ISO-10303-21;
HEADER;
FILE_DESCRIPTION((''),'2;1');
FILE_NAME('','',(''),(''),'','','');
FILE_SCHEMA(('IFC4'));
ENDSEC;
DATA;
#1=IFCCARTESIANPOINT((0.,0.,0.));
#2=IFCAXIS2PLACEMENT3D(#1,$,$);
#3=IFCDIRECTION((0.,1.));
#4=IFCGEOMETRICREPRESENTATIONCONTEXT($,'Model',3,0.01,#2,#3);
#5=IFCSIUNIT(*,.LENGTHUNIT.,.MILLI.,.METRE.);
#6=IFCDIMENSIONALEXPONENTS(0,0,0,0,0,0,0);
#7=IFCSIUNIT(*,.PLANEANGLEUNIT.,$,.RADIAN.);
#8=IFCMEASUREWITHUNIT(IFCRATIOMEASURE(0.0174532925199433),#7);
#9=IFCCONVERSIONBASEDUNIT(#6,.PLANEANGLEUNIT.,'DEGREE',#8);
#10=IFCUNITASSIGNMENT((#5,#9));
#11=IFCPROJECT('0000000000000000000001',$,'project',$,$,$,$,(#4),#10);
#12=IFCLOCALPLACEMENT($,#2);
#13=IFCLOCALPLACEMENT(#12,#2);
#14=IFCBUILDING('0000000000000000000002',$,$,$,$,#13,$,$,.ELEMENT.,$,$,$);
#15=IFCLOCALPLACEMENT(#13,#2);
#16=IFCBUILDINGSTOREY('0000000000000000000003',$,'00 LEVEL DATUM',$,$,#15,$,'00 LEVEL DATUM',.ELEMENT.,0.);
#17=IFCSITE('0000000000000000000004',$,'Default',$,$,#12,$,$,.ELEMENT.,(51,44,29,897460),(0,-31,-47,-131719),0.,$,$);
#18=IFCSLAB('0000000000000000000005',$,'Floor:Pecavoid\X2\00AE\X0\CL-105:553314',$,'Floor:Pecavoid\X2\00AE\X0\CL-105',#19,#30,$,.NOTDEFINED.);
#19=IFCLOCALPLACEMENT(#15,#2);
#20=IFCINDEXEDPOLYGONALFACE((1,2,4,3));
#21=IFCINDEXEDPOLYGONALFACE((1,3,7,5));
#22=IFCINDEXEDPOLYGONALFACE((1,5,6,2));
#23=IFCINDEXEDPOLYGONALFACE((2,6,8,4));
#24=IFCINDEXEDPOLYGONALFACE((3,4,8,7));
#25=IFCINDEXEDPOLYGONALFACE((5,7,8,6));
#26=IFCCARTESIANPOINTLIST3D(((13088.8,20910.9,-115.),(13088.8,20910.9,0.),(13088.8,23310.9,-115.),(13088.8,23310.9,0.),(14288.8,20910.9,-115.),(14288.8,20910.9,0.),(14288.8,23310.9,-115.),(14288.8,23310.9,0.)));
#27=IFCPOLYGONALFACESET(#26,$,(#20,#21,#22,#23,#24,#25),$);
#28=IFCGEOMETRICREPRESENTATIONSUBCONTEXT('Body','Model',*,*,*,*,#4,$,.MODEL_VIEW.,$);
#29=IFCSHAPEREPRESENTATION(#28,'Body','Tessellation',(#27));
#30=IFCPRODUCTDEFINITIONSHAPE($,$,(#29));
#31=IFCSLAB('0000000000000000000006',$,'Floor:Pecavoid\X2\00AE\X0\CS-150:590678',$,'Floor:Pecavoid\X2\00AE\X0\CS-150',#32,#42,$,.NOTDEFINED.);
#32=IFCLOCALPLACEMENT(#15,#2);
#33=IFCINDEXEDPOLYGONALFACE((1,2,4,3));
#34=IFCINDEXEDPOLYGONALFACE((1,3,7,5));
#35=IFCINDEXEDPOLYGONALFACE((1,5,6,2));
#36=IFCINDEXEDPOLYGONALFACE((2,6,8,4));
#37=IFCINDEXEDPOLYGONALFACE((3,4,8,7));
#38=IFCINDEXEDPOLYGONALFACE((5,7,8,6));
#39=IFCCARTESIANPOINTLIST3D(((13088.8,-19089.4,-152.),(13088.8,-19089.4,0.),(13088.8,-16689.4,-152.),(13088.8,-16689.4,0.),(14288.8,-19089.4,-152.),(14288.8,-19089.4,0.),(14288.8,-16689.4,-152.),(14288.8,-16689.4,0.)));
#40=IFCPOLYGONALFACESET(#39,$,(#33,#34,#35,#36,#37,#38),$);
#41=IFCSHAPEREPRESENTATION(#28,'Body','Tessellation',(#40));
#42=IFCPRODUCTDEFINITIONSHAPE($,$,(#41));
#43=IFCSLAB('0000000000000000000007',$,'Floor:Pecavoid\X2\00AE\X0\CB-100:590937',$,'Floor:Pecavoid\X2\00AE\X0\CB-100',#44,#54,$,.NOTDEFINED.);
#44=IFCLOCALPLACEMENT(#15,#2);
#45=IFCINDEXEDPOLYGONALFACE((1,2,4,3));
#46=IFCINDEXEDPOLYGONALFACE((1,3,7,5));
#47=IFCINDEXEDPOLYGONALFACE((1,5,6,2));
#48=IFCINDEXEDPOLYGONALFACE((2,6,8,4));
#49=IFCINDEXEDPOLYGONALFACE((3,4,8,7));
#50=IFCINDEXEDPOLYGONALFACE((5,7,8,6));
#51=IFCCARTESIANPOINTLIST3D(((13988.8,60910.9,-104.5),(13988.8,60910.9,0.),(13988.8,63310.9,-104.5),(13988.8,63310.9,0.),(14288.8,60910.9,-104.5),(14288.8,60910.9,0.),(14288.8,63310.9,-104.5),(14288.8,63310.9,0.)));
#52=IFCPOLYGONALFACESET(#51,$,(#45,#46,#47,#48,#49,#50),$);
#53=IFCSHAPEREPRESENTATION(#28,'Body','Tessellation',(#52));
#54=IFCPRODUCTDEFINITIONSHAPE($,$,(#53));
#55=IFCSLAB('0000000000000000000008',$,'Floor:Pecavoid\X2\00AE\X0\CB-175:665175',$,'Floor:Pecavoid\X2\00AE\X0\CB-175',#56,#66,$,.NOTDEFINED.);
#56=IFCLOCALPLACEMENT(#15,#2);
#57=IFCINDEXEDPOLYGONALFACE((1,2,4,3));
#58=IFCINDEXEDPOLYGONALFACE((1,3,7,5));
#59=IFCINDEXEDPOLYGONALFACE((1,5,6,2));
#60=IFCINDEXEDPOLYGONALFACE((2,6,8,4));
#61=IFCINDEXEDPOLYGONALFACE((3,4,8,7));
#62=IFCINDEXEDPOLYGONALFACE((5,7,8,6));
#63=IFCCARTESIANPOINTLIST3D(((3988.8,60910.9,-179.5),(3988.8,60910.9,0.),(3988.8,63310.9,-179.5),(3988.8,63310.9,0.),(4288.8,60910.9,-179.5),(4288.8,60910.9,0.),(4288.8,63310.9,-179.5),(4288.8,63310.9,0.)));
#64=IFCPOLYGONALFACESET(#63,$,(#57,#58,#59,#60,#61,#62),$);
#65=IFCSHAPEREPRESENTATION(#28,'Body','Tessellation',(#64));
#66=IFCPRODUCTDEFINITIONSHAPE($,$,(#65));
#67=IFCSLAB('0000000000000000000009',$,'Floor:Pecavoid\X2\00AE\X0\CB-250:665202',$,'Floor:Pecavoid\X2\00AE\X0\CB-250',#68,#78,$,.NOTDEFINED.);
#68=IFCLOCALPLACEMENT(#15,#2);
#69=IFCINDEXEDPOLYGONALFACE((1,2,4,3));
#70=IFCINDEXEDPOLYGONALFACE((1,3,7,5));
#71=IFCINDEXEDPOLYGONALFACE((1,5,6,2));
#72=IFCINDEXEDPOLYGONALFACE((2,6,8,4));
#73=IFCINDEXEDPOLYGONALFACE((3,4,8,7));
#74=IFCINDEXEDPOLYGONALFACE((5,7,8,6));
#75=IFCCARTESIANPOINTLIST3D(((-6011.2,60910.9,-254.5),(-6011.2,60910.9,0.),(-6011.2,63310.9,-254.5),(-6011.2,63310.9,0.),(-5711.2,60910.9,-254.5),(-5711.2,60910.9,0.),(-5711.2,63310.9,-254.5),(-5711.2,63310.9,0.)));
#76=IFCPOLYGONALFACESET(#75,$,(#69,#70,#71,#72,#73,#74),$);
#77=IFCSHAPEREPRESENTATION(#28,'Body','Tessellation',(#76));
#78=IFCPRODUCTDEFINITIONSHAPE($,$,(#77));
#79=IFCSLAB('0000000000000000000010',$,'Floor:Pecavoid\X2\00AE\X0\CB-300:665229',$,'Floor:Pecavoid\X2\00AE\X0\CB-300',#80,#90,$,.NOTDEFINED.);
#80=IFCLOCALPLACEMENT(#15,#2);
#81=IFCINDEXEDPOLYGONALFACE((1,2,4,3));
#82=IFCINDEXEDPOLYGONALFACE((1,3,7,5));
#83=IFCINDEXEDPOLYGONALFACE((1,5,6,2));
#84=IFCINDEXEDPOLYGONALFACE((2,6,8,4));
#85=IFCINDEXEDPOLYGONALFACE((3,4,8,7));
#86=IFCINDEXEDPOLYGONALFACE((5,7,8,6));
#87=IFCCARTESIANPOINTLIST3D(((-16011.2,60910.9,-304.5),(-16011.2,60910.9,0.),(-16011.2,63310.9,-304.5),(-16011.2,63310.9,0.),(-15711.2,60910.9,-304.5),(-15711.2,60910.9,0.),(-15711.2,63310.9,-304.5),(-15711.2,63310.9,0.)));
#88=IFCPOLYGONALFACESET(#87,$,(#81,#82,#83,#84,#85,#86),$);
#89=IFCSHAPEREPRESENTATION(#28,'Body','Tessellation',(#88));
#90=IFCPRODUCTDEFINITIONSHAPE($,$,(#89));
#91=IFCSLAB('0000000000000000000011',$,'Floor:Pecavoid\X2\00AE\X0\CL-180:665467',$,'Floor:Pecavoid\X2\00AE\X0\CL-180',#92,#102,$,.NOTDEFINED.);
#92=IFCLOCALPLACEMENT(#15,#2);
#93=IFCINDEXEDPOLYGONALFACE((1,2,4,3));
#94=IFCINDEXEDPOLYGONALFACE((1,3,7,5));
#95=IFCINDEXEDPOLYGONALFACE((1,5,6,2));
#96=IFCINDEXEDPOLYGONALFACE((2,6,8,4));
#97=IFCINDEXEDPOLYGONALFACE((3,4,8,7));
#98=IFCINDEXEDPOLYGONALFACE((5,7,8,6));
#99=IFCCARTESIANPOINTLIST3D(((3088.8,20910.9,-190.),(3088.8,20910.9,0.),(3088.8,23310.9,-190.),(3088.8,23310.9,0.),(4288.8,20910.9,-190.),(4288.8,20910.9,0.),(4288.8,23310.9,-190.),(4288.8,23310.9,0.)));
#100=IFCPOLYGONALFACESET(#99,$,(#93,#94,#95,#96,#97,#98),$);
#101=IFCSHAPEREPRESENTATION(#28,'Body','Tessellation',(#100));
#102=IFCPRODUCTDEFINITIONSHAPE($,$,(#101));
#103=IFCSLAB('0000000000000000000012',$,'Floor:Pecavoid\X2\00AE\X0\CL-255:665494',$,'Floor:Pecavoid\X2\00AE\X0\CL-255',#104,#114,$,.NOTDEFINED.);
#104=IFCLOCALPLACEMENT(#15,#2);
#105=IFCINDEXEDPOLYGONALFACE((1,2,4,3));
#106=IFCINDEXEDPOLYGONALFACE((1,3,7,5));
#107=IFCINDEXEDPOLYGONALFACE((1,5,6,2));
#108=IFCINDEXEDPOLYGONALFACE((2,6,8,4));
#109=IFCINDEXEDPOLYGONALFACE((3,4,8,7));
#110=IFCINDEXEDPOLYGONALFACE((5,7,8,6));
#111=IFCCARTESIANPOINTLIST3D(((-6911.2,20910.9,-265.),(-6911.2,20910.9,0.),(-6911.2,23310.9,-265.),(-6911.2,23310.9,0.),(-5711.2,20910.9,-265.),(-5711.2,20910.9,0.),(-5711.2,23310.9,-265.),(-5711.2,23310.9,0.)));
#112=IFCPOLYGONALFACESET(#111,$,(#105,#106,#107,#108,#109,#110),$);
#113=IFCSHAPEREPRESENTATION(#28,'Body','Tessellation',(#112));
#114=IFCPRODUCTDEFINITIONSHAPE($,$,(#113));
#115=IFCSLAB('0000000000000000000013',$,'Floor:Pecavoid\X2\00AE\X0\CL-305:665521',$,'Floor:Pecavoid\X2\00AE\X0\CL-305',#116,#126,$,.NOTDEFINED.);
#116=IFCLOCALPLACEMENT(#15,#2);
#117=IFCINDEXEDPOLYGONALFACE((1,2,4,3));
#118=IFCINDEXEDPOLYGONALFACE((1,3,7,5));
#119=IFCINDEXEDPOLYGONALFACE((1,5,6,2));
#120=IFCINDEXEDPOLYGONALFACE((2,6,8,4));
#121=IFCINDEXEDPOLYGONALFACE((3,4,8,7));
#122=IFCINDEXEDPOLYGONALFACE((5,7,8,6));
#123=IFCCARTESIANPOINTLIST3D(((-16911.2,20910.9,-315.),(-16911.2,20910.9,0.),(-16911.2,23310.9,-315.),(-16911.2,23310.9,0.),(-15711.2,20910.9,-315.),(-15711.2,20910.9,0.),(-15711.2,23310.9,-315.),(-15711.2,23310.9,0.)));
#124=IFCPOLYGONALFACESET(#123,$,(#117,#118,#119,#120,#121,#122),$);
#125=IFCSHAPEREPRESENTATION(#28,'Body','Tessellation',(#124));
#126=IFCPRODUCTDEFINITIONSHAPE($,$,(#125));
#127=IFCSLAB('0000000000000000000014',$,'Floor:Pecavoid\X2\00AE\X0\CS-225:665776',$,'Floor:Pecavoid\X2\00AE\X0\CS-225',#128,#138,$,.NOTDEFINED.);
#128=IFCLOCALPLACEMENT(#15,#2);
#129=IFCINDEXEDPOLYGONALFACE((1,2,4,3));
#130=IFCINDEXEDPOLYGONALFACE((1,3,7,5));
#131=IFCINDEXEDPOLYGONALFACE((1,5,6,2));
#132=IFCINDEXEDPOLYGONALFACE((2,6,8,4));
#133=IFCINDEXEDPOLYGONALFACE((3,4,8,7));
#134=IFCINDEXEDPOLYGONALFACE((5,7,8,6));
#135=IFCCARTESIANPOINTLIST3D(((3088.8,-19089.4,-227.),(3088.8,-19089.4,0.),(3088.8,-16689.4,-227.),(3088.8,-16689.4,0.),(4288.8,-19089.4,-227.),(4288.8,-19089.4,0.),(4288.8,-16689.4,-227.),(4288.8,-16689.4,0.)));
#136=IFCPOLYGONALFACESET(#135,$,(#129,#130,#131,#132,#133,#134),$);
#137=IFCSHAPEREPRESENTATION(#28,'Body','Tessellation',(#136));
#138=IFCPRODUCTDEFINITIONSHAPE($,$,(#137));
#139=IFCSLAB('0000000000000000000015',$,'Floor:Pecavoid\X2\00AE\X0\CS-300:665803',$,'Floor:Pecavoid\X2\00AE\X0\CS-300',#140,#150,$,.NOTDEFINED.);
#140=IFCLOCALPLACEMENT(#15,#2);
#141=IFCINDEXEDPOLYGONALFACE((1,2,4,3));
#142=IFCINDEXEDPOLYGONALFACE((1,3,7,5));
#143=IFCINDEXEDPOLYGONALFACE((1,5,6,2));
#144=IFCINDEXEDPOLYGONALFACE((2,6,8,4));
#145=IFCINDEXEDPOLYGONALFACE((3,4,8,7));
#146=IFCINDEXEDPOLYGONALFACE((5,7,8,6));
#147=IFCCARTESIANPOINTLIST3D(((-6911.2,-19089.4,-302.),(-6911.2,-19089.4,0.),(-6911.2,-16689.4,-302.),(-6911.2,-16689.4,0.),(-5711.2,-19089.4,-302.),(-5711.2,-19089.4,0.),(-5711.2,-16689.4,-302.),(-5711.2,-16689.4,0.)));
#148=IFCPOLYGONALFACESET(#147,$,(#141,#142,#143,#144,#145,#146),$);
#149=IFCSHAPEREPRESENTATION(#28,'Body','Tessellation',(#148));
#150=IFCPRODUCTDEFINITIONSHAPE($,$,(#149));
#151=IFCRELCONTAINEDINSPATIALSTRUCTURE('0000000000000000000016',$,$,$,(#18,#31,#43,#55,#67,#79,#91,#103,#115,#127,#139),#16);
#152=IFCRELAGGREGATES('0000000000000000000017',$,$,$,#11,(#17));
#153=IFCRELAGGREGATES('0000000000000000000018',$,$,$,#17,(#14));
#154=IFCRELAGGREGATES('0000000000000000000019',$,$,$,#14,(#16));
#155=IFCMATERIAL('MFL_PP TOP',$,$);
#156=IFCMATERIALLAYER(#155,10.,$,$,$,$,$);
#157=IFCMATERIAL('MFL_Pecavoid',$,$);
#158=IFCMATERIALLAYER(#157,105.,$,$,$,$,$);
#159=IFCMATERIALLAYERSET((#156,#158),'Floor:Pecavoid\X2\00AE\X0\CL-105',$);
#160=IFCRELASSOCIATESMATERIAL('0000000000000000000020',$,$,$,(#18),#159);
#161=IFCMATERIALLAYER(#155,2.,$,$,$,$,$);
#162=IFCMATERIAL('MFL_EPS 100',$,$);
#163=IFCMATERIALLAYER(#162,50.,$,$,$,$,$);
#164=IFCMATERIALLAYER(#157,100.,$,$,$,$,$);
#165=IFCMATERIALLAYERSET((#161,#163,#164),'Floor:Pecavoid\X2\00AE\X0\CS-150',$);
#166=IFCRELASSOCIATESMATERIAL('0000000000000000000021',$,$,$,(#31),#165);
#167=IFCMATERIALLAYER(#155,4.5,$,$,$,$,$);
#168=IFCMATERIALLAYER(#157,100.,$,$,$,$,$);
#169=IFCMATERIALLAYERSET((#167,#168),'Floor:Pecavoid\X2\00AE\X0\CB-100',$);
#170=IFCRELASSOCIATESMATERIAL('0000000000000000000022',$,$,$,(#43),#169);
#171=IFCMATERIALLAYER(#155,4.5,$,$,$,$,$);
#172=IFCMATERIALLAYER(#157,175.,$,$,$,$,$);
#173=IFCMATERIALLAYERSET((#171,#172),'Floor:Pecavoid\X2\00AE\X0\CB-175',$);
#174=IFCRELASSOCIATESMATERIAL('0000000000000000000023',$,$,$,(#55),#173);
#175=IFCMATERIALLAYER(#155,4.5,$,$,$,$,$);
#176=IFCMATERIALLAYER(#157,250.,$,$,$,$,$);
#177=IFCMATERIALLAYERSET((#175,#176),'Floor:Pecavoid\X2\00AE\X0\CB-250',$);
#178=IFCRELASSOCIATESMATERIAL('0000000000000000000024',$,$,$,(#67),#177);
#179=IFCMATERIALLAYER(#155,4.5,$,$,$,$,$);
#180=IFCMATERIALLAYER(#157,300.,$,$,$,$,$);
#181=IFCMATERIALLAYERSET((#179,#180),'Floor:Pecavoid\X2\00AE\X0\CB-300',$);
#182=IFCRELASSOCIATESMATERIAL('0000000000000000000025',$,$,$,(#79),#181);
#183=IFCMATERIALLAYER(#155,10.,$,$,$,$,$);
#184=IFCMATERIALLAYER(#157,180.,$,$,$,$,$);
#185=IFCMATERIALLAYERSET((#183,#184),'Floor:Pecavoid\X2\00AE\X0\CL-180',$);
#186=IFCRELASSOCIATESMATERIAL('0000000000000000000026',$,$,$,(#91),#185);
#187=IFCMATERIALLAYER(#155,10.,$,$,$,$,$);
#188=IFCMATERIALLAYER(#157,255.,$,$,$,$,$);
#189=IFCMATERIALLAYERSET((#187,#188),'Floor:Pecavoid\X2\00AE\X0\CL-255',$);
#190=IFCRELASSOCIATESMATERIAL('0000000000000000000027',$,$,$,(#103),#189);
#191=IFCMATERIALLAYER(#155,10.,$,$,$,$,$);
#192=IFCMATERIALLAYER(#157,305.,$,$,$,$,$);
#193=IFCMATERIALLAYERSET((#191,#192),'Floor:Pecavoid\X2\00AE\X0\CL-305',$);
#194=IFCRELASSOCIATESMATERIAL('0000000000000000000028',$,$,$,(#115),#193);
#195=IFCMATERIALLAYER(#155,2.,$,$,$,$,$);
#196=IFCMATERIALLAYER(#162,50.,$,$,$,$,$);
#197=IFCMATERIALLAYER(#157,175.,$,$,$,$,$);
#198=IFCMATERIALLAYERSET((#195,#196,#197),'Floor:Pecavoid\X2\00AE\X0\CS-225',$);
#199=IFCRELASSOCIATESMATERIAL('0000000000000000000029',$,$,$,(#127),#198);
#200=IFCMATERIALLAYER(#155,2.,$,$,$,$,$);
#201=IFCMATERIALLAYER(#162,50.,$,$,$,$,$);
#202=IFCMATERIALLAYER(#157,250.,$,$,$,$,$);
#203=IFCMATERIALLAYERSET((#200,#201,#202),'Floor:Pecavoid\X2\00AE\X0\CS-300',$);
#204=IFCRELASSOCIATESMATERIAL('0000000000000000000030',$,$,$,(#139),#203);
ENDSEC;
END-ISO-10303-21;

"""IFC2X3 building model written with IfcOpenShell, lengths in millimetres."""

from ifc_helpers import new_model, entity, si_unit, converted_unit, direction, frame, frame_2d, origin, origin_2d_with_axis, place, context, subcontext, project, spatial, rectangle, extrude, material, layer, layer_set, layer_usage, element, save


model = new_model("IFC2X3")

# Units and contexts
model_context = context("Model", 3, precision=0.01, world=origin(), true_north=direction((0.0, 1.0)))
body_context = subcontext(model_context, "Body", "Model", "MODEL_VIEW")
ifc_project = project(units=[si_unit("LENGTHUNIT", "METRE", prefix="MILLI"), converted_unit("PLANEANGLEUNIT", "DEGREE", entity("IfcRatioMeasure", 0.0174532925199433), si_unit("PLANEANGLEUNIT", "RADIAN"), dimensions=[0, 0, 0, 0, 0, 0, 0])], contexts=[model_context])

# Site, building, storey
site_placement = place(None, origin())
site = spatial("IfcSite", under=ifc_project, at=site_placement, Name="Default", CompositionType="ELEMENT", RefLatitude=(51, 44, 29, 897460), RefLongitude=(0, -31, -47, -131719), RefElevation=0.0)
building_placement = place(site_placement, origin())
building = spatial("IfcBuilding", under=site, at=building_placement, CompositionType="ELEMENT")
storey_placement = place(building_placement, origin())
storey = spatial("IfcBuildingStorey", under=building, at=storey_placement, Name="00 LEVEL DATUM", LongName="00 LEVEL DATUM", CompositionType="ELEMENT", Elevation=0.0)

# Slabs
ifc_material_1 = material(Name="MFL_PP TOP")
ifc_layer_1 = layer(ifc_material_1, 10.0)
ifc_material_2 = material(Name="MFL_Pecavoid")
ifc_layer_2 = layer(ifc_material_2, 105.0)
ifc_layer_set_1 = layer_set([ifc_layer_1, ifc_layer_2], Name="Floor:Pecavoid®CL-105")
ifc_layer_usage_1 = layer_usage(ifc_layer_set_1, "AXIS3", "POSITIVE", 0.0)
slab_1_placement = place(storey_placement, origin())
element("IfcSlab", 1, at=slab_1_placement, inside=storey, material=ifc_layer_usage_1, Name="Floor:Pecavoid®CL-105:553314", ObjectType="Floor:Pecavoid®CL-105", PredefinedType="NOTDEFINED", context=body_context, shape_type="SweptSolid", body=[
    extrude(rectangle(XDim=2400.0, YDim=1200.0, at=origin_2d_with_axis()), frame((13688.8, 22110.9, 0.0), z_axis=(0.0, 0.0, -1.0), x_axis=(0.0, 1.0, 0.0)), (0.0, 0.0, 1.0), 115.0),
])
ifc_layer_3 = layer(ifc_material_1, 2.0)
ifc_material_3 = material(Name="MFL_EPS 100")
ifc_layer_4 = layer(ifc_material_3, 50.0)
ifc_layer_5 = layer(ifc_material_2, 100.0)
ifc_layer_set_2 = layer_set([ifc_layer_3, ifc_layer_4, ifc_layer_5], Name="Floor:Pecavoid®CS-150")
ifc_layer_usage_2 = layer_usage(ifc_layer_set_2, "AXIS3", "POSITIVE", 0.0)
slab_2_placement = place(storey_placement, origin())
element("IfcSlab", 2, at=slab_2_placement, inside=storey, material=ifc_layer_usage_2, Name="Floor:Pecavoid®CS-150:590678", ObjectType="Floor:Pecavoid®CS-150", PredefinedType="NOTDEFINED", context=body_context, shape_type="SweptSolid", body=[
    extrude(rectangle(XDim=2400.0, YDim=1200.0, at=origin_2d_with_axis()), frame((13688.8, -17889.4, 0.0), z_axis=(0.0, 0.0, -1.0), x_axis=(0.0, 1.0, 0.0)), (0.0, 0.0, 1.0), 152.0),
])
ifc_layer_6 = layer(ifc_material_1, 4.5)
ifc_layer_7 = layer(ifc_material_2, 100.0)
ifc_layer_set_3 = layer_set([ifc_layer_6, ifc_layer_7], Name="Floor:Pecavoid®CB-100")
ifc_layer_usage_3 = layer_usage(ifc_layer_set_3, "AXIS3", "POSITIVE", 0.0)
slab_3_placement = place(storey_placement, origin())
element("IfcSlab", 3, at=slab_3_placement, inside=storey, material=ifc_layer_usage_3, Name="Floor:Pecavoid®CB-100:590937", ObjectType="Floor:Pecavoid®CB-100", PredefinedType="NOTDEFINED", context=body_context, shape_type="SweptSolid", body=[
    extrude(rectangle(XDim=2400.0, YDim=300.0, at=origin_2d_with_axis()), frame((14138.8, 62110.9, 0.0), z_axis=(0.0, 0.0, -1.0), x_axis=(0.0, 1.0, 0.0)), (0.0, 0.0, 1.0), 104.5),
])
ifc_layer_8 = layer(ifc_material_1, 4.5)
ifc_layer_9 = layer(ifc_material_2, 175.0)
ifc_layer_set_4 = layer_set([ifc_layer_8, ifc_layer_9], Name="Floor:Pecavoid®CB-175")
ifc_layer_usage_4 = layer_usage(ifc_layer_set_4, "AXIS3", "POSITIVE", 0.0)
slab_4_placement = place(storey_placement, origin())
element("IfcSlab", 4, at=slab_4_placement, inside=storey, material=ifc_layer_usage_4, Name="Floor:Pecavoid®CB-175:665175", ObjectType="Floor:Pecavoid®CB-175", PredefinedType="NOTDEFINED", context=body_context, shape_type="SweptSolid", body=[
    extrude(rectangle(XDim=2400.0, YDim=300.0, at=frame_2d((0.0, 0.0), x_axis=(1.0, 0.0))), frame((4138.8, 62110.9, 0.0), z_axis=(0.0, 0.0, -1.0), x_axis=(0.0, 1.0, 0.0)), (0.0, 0.0, 1.0), 179.5),
])
ifc_layer_10 = layer(ifc_material_1, 4.5)
ifc_layer_11 = layer(ifc_material_2, 250.0)
ifc_layer_set_5 = layer_set([ifc_layer_10, ifc_layer_11], Name="Floor:Pecavoid®CB-250")
ifc_layer_usage_5 = layer_usage(ifc_layer_set_5, "AXIS3", "POSITIVE", 0.0)
slab_5_placement = place(storey_placement, origin())
element("IfcSlab", 5, at=slab_5_placement, inside=storey, material=ifc_layer_usage_5, Name="Floor:Pecavoid®CB-250:665202", ObjectType="Floor:Pecavoid®CB-250", PredefinedType="NOTDEFINED", context=body_context, shape_type="SweptSolid", body=[
    extrude(rectangle(XDim=2400.0, YDim=300.0, at=origin_2d_with_axis()), frame((-5861.2, 62110.9, 0.0), z_axis=(0.0, 0.0, -1.0), x_axis=(0.0, 1.0, 0.0)), (0.0, 0.0, 1.0), 254.5),
])
ifc_layer_12 = layer(ifc_material_1, 4.5)
ifc_layer_13 = layer(ifc_material_2, 300.0)
ifc_layer_set_6 = layer_set([ifc_layer_12, ifc_layer_13], Name="Floor:Pecavoid®CB-300")
ifc_layer_usage_6 = layer_usage(ifc_layer_set_6, "AXIS3", "POSITIVE", 0.0)
slab_6_placement = place(storey_placement, origin())
element("IfcSlab", 6, at=slab_6_placement, inside=storey, material=ifc_layer_usage_6, Name="Floor:Pecavoid®CB-300:665229", ObjectType="Floor:Pecavoid®CB-300", PredefinedType="NOTDEFINED", context=body_context, shape_type="SweptSolid", body=[
    extrude(rectangle(XDim=2400.0, YDim=300.0, at=origin_2d_with_axis()), frame((-15861.2, 62110.9, 0.0), z_axis=(0.0, 0.0, -1.0), x_axis=(0.0, 1.0, 0.0)), (0.0, 0.0, 1.0), 304.5),
])
ifc_layer_14 = layer(ifc_material_1, 10.0)
ifc_layer_15 = layer(ifc_material_2, 180.0)
ifc_layer_set_7 = layer_set([ifc_layer_14, ifc_layer_15], Name="Floor:Pecavoid®CL-180")
ifc_layer_usage_7 = layer_usage(ifc_layer_set_7, "AXIS3", "POSITIVE", 0.0)
slab_7_placement = place(storey_placement, origin())
element("IfcSlab", 7, at=slab_7_placement, inside=storey, material=ifc_layer_usage_7, Name="Floor:Pecavoid®CL-180:665467", ObjectType="Floor:Pecavoid®CL-180", PredefinedType="NOTDEFINED", context=body_context, shape_type="SweptSolid", body=[
    extrude(rectangle(XDim=2400.0, YDim=1200.0, at=frame_2d((0.0, 0.0), x_axis=(1.0, 0.0))), frame((3688.8, 22110.9, 0.0), z_axis=(0.0, 0.0, -1.0), x_axis=(0.0, 1.0, 0.0)), (0.0, 0.0, 1.0), 190.0),
])
ifc_layer_16 = layer(ifc_material_1, 10.0)
ifc_layer_17 = layer(ifc_material_2, 255.0)
ifc_layer_set_8 = layer_set([ifc_layer_16, ifc_layer_17], Name="Floor:Pecavoid®CL-255")
ifc_layer_usage_8 = layer_usage(ifc_layer_set_8, "AXIS3", "POSITIVE", 0.0)
slab_8_placement = place(storey_placement, origin())
element("IfcSlab", 8, at=slab_8_placement, inside=storey, material=ifc_layer_usage_8, Name="Floor:Pecavoid®CL-255:665494", ObjectType="Floor:Pecavoid®CL-255", PredefinedType="NOTDEFINED", context=body_context, shape_type="SweptSolid", body=[
    extrude(rectangle(XDim=2400.0, YDim=1200.0, at=origin_2d_with_axis()), frame((-6311.2, 22110.9, 0.0), z_axis=(0.0, 0.0, -1.0), x_axis=(0.0, 1.0, 0.0)), (0.0, 0.0, 1.0), 265.0),
])
ifc_layer_18 = layer(ifc_material_1, 10.0)
ifc_layer_19 = layer(ifc_material_2, 305.0)
ifc_layer_set_9 = layer_set([ifc_layer_18, ifc_layer_19], Name="Floor:Pecavoid®CL-305")
ifc_layer_usage_9 = layer_usage(ifc_layer_set_9, "AXIS3", "POSITIVE", 0.0)
slab_9_placement = place(storey_placement, origin())
element("IfcSlab", 9, at=slab_9_placement, inside=storey, material=ifc_layer_usage_9, Name="Floor:Pecavoid®CL-305:665521", ObjectType="Floor:Pecavoid®CL-305", PredefinedType="NOTDEFINED", context=body_context, shape_type="SweptSolid", body=[
    extrude(rectangle(XDim=2400.0, YDim=1200.0, at=frame_2d((0.0, 0.0), x_axis=(1.0, 0.0))), frame((-16311.2, 22110.9, 0.0), z_axis=(0.0, 0.0, -1.0), x_axis=(0.0, 1.0, 0.0)), (0.0, 0.0, 1.0), 315.0),
])
ifc_layer_20 = layer(ifc_material_1, 2.0)
ifc_layer_21 = layer(ifc_material_3, 50.0)
ifc_layer_22 = layer(ifc_material_2, 175.0)
ifc_layer_set_10 = layer_set([ifc_layer_20, ifc_layer_21, ifc_layer_22], Name="Floor:Pecavoid®CS-225")
ifc_layer_usage_10 = layer_usage(ifc_layer_set_10, "AXIS3", "POSITIVE", 0.0)
slab_10_placement = place(storey_placement, origin())
element("IfcSlab", 10, at=slab_10_placement, inside=storey, material=ifc_layer_usage_10, Name="Floor:Pecavoid®CS-225:665776", ObjectType="Floor:Pecavoid®CS-225", PredefinedType="NOTDEFINED", context=body_context, shape_type="SweptSolid", body=[
    extrude(rectangle(XDim=2400.0, YDim=1200.0, at=frame_2d((0.0, 0.0), x_axis=(1.0, 0.0))), frame((3688.8, -17889.4, 0.0), z_axis=(0.0, 0.0, -1.0), x_axis=(0.0, 1.0, 0.0)), (0.0, 0.0, 1.0), 227.0),
])
ifc_layer_23 = layer(ifc_material_1, 2.0)
ifc_layer_24 = layer(ifc_material_3, 50.0)
ifc_layer_25 = layer(ifc_material_2, 250.0)
ifc_layer_set_11 = layer_set([ifc_layer_23, ifc_layer_24, ifc_layer_25], Name="Floor:Pecavoid®CS-300")
ifc_layer_usage_11 = layer_usage(ifc_layer_set_11, "AXIS3", "POSITIVE", 0.0)
slab_11_placement = place(storey_placement, origin())
element("IfcSlab", 11, at=slab_11_placement, inside=storey, material=ifc_layer_usage_11, Name="Floor:Pecavoid®CS-300:665803", ObjectType="Floor:Pecavoid®CS-300", PredefinedType="NOTDEFINED", context=body_context, shape_type="SweptSolid", body=[
    extrude(rectangle(XDim=2400.0, YDim=1200.0, at=origin_2d_with_axis()), frame((-6311.2, -17889.4, 0.0), z_axis=(0.0, 0.0, -1.0), x_axis=(0.0, 1.0, 0.0)), (0.0, 0.0, 1.0), 302.0),
])

save(model, "model.ifc")
